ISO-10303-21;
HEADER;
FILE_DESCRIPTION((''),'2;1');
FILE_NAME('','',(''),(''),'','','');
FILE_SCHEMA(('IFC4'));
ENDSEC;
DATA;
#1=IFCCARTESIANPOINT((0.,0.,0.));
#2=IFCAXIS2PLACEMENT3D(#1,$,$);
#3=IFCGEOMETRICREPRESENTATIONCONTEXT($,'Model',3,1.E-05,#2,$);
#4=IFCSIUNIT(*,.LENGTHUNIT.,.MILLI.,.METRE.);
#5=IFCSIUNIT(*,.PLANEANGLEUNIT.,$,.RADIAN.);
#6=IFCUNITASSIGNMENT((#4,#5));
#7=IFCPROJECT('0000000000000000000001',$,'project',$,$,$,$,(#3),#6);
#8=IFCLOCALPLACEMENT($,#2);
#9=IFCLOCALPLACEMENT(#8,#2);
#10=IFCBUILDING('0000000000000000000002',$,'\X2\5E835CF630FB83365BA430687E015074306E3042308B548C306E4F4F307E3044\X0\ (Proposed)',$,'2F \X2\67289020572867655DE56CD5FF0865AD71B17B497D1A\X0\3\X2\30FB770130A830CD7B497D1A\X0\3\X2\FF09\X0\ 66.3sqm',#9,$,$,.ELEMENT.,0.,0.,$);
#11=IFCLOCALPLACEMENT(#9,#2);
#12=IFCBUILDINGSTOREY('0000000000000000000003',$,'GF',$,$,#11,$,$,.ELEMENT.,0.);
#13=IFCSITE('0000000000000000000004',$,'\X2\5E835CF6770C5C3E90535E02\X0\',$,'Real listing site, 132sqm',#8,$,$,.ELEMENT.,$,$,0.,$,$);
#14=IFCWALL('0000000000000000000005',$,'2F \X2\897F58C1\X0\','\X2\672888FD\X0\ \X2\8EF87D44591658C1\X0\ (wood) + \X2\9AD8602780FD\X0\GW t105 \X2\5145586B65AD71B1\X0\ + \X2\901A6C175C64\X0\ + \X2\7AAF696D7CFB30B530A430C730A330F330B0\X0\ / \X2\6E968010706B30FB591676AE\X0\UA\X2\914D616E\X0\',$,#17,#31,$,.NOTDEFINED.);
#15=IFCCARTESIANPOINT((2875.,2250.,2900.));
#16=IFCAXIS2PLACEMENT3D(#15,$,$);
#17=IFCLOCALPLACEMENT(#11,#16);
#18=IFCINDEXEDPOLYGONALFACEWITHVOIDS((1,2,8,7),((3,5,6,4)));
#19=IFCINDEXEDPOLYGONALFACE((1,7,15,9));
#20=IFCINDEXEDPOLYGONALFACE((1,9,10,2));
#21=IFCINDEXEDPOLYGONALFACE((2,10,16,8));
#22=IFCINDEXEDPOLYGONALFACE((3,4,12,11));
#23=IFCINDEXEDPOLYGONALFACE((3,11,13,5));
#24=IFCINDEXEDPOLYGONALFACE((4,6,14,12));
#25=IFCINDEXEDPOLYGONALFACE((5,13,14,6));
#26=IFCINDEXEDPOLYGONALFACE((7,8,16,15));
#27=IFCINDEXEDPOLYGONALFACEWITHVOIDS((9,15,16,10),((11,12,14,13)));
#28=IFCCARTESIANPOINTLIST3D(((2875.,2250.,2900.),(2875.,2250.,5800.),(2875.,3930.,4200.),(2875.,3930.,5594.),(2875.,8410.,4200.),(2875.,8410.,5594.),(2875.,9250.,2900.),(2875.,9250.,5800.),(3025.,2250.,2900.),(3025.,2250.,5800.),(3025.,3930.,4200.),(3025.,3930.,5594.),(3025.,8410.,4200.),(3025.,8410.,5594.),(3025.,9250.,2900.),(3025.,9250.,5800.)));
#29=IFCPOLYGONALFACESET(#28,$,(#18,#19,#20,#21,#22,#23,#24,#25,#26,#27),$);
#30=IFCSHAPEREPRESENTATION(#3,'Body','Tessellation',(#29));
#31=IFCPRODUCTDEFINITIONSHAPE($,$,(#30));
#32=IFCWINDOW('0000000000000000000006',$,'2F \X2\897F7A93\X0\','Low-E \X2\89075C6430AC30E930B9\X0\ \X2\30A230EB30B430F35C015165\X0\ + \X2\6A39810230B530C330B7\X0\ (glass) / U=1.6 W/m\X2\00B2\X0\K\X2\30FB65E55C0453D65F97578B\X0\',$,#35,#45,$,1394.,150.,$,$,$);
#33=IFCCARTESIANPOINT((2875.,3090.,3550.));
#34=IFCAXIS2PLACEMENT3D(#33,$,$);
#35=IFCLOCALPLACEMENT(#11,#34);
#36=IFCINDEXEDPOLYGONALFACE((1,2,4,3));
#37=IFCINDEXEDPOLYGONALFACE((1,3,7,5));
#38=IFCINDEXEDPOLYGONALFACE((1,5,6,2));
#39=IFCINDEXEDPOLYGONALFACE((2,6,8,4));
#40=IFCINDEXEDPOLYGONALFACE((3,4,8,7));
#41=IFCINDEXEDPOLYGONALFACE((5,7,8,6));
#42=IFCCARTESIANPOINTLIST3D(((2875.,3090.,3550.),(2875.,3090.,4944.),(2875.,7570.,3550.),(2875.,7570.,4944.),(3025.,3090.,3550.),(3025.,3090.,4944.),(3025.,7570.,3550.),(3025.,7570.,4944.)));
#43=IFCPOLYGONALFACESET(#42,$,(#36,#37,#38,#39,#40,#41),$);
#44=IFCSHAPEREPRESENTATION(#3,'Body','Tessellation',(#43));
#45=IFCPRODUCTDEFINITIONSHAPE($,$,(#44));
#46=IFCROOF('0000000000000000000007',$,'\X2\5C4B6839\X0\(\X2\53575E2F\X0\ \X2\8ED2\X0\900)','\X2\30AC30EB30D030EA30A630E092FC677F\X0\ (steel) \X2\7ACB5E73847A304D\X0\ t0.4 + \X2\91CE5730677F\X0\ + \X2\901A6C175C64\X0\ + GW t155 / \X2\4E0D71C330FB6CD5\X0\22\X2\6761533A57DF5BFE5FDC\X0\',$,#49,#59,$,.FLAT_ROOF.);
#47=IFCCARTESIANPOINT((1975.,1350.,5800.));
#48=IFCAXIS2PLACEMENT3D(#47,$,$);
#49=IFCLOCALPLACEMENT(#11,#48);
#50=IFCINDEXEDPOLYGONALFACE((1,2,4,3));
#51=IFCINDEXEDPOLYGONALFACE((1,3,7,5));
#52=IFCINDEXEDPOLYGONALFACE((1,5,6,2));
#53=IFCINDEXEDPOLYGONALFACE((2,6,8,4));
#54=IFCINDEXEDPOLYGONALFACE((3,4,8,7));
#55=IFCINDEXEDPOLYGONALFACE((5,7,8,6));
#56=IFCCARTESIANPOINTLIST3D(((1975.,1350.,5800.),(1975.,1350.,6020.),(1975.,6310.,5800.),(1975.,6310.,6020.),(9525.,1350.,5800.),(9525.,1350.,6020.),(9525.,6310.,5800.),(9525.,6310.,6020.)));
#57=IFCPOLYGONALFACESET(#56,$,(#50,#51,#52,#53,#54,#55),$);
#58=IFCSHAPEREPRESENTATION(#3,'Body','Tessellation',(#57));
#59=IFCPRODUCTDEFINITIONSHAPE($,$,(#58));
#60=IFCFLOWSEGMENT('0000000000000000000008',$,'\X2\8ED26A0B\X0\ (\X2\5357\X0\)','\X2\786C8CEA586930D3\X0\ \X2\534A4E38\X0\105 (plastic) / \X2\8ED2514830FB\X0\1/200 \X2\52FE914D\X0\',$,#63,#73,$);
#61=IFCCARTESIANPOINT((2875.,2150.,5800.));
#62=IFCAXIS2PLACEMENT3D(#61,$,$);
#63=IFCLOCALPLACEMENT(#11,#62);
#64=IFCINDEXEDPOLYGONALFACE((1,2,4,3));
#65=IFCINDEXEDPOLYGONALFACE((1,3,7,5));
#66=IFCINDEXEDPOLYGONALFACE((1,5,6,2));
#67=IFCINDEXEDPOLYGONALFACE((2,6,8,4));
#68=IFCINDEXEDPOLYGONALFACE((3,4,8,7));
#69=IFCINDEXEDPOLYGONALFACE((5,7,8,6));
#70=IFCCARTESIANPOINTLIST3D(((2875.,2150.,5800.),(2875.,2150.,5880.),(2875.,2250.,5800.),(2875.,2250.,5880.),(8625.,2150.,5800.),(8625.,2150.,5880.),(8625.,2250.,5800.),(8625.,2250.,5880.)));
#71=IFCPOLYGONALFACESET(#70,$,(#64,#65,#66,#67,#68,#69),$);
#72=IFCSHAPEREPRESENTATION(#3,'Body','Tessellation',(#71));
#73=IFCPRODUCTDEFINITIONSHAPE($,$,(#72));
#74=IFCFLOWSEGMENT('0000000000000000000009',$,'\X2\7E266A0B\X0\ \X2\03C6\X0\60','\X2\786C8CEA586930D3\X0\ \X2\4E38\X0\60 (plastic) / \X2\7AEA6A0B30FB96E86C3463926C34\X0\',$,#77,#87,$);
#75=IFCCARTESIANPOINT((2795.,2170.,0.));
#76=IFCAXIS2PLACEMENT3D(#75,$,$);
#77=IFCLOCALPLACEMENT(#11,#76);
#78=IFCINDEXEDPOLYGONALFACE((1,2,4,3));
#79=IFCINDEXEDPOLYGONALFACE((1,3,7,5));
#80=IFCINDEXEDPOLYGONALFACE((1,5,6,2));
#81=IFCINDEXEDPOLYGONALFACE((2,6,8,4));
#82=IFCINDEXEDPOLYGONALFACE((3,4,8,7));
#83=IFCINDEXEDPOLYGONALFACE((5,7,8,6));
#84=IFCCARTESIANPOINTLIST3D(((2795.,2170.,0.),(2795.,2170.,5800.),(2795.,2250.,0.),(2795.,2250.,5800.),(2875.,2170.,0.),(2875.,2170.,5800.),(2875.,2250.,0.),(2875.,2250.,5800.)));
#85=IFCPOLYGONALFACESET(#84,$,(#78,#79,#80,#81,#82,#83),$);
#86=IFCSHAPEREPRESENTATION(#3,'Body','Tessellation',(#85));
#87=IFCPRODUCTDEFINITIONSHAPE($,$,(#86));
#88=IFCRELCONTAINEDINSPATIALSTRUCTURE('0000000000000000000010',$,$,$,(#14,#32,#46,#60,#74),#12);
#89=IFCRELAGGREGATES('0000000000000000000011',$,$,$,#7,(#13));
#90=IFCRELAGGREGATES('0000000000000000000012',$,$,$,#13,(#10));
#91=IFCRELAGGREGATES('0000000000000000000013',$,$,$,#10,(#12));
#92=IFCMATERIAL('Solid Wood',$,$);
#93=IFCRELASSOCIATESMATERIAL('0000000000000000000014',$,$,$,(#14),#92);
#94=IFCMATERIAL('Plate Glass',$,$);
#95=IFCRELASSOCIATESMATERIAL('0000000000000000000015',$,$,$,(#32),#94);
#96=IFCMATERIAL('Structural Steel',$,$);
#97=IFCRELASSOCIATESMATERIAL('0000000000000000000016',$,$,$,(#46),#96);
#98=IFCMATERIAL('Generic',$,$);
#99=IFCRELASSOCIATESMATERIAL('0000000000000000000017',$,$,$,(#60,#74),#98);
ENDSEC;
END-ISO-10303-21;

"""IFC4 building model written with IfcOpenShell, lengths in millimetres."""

from ifc_helpers import new_model, si_unit, frame, frame_2d, origin, place, context, project, spatial, rectangle, extrude, material, element, fill, save


model = new_model("IFC4")

# Units and contexts
model_context = context("Model", 3, precision=1e-05, world=origin())
ifc_project = project(units=[si_unit("LENGTHUNIT", "METRE", prefix="MILLI"), si_unit("PLANEANGLEUNIT", "RADIAN")], contexts=[model_context])

# Site, building, storey
site_placement = place(None, origin())
site = spatial("IfcSite", under=ifc_project, at=site_placement, Name="広島県尾道市", ObjectType="Real listing site, 132sqm", CompositionType="ELEMENT", RefElevation=0.0)
building_placement = place(site_placement, origin())
building = spatial("IfcBuilding", under=site, at=building_placement, Name="広島・茶室と縁側のある和の住まい (Proposed)", ObjectType="2F 木造在来工法（断熱等級3・省エネ等級3） 66.3sqm", CompositionType="ELEMENT", ElevationOfRefHeight=0.0, ElevationOfTerrain=0.0)
storey_placement = place(building_placement, origin())
storey = spatial("IfcBuildingStorey", under=building, at=storey_placement, Name="GF", CompositionType="ELEMENT", Elevation=0.0)

# Shared definitions
ifc_material_1 = material(Name="Solid Wood")

# Shared definitions
ifc_material_2 = material(Name="Plate Glass")

# Wall, opening, window
wall_1_placement = place(storey_placement, frame((2875.0, 2250.0, 2900.0)))
wall_1 = element("IfcWall", 1, at=wall_1_placement, inside=storey, material=ifc_material_1, Name="2F 西壁", Description="木製 軸組外壁 (wood) + 高性能GW t105 充填断熱 + 通気層 + 窯業系サイディング / 準耐火・外皮UA配慮", PredefinedType="NOTDEFINED", context=model_context, shape_type="SweptSolid", body=[
    extrude(rectangle(XDim=150.0, YDim=7000.0, at=frame_2d((75.0, 3500.0))), frame((2875.0, 2250.0, 2900.0)), (0.0, 0.0, 1.0), 2900.0),
])
opening_1_placement = place(storey_placement, frame((2875.0, 3090.0, 3550.0)))
opening_1 = element("IfcOpeningElement", 2, at=opening_1_placement, cuts=wall_1, PredefinedType="NOTDEFINED", context=model_context, shape_type="SweptSolid", body=[
    extrude(rectangle(XDim=150.0, YDim=4480.0, at=frame_2d((75.0, 2240.0))), frame((2875.0, 3090.0, 3550.0)), (0.0, 0.0, 1.0), 1394.0),
])
window_1_placement = place(storey_placement, frame((2875.0, 3090.0, 3550.0)))
window_1 = element("IfcWindow", 3, at=window_1_placement, inside=storey, material=ifc_material_2, Name="2F 西窓", Description="Low-E 複層ガラス アルゴン封入 + 樹脂サッシ (glass) / U=1.6 W/m²K・日射取得型", OverallHeight=1394.0, OverallWidth=150.0, context=model_context, shape_type="SweptSolid", body=[
    extrude(rectangle(XDim=150.0, YDim=4480.0, at=frame_2d((75.0, 2240.0))), frame((2875.0, 3090.0, 3550.0)), (0.0, 0.0, 1.0), 1394.0),
])
fill(opening_1, window_1)

# Roof
ifc_material_3 = material(Name="Structural Steel")
for number, where, name in (
    (4, (1975.0, 1350.0, 5800.0), "屋根(南帯 軒900)"),
):
    element("IfcRoof", number, at=place(storey_placement, frame(where)), inside=storey, material=ifc_material_3, Name=name, Description="ガルバリウム鋼板 (steel) 立平葺き t0.4 + 野地板 + 通気層 + GW t155 / 不燃・法22条区域対応", PredefinedType="FLAT_ROOF", context=model_context, shape_type="SweptSolid", body=[
        extrude(rectangle(XDim=7550.0, YDim=4960.0, at=frame_2d((3775.0, 2480.0))), frame((1975.0, 1350.0, 5800.0)), (0.0, 0.0, 1.0), 220.0),
    ])

# Flow segments
ifc_material_4 = material(Name="Generic")
flow_segment_1_placement = place(storey_placement, frame((2875.0, 2150.0, 5800.0)))
element("IfcFlowSegment", 5, at=flow_segment_1_placement, inside=storey, material=ifc_material_4, Name="軒樋 (南)", Description="硬質塩ビ 半丸105 (plastic) / 軒先・1/200 勾配", context=model_context, shape_type="SweptSolid", body=[
    extrude(rectangle(XDim=5750.0, YDim=100.0, at=frame_2d((2875.0, 50.0))), frame((2875.0, 2150.0, 5800.0)), (0.0, 0.0, 1.0), 80.0),
])
flow_segment_2_placement = place(storey_placement, frame((2795.0, 2170.0, 0.0)))
element("IfcFlowSegment", 6, at=flow_segment_2_placement, inside=storey, material=ifc_material_4, Name="縦樋 φ60", Description="硬質塩ビ 丸60 (plastic) / 竪樋・雨水排水", context=model_context, shape_type="SweptSolid", body=[
    extrude(rectangle(XDim=80.0, YDim=80.0, at=frame_2d((40.0, 40.0))), frame((2795.0, 2170.0, 0.0)), (0.0, 0.0, 1.0), 5800.0),
])

save(model, "model.ifc")
